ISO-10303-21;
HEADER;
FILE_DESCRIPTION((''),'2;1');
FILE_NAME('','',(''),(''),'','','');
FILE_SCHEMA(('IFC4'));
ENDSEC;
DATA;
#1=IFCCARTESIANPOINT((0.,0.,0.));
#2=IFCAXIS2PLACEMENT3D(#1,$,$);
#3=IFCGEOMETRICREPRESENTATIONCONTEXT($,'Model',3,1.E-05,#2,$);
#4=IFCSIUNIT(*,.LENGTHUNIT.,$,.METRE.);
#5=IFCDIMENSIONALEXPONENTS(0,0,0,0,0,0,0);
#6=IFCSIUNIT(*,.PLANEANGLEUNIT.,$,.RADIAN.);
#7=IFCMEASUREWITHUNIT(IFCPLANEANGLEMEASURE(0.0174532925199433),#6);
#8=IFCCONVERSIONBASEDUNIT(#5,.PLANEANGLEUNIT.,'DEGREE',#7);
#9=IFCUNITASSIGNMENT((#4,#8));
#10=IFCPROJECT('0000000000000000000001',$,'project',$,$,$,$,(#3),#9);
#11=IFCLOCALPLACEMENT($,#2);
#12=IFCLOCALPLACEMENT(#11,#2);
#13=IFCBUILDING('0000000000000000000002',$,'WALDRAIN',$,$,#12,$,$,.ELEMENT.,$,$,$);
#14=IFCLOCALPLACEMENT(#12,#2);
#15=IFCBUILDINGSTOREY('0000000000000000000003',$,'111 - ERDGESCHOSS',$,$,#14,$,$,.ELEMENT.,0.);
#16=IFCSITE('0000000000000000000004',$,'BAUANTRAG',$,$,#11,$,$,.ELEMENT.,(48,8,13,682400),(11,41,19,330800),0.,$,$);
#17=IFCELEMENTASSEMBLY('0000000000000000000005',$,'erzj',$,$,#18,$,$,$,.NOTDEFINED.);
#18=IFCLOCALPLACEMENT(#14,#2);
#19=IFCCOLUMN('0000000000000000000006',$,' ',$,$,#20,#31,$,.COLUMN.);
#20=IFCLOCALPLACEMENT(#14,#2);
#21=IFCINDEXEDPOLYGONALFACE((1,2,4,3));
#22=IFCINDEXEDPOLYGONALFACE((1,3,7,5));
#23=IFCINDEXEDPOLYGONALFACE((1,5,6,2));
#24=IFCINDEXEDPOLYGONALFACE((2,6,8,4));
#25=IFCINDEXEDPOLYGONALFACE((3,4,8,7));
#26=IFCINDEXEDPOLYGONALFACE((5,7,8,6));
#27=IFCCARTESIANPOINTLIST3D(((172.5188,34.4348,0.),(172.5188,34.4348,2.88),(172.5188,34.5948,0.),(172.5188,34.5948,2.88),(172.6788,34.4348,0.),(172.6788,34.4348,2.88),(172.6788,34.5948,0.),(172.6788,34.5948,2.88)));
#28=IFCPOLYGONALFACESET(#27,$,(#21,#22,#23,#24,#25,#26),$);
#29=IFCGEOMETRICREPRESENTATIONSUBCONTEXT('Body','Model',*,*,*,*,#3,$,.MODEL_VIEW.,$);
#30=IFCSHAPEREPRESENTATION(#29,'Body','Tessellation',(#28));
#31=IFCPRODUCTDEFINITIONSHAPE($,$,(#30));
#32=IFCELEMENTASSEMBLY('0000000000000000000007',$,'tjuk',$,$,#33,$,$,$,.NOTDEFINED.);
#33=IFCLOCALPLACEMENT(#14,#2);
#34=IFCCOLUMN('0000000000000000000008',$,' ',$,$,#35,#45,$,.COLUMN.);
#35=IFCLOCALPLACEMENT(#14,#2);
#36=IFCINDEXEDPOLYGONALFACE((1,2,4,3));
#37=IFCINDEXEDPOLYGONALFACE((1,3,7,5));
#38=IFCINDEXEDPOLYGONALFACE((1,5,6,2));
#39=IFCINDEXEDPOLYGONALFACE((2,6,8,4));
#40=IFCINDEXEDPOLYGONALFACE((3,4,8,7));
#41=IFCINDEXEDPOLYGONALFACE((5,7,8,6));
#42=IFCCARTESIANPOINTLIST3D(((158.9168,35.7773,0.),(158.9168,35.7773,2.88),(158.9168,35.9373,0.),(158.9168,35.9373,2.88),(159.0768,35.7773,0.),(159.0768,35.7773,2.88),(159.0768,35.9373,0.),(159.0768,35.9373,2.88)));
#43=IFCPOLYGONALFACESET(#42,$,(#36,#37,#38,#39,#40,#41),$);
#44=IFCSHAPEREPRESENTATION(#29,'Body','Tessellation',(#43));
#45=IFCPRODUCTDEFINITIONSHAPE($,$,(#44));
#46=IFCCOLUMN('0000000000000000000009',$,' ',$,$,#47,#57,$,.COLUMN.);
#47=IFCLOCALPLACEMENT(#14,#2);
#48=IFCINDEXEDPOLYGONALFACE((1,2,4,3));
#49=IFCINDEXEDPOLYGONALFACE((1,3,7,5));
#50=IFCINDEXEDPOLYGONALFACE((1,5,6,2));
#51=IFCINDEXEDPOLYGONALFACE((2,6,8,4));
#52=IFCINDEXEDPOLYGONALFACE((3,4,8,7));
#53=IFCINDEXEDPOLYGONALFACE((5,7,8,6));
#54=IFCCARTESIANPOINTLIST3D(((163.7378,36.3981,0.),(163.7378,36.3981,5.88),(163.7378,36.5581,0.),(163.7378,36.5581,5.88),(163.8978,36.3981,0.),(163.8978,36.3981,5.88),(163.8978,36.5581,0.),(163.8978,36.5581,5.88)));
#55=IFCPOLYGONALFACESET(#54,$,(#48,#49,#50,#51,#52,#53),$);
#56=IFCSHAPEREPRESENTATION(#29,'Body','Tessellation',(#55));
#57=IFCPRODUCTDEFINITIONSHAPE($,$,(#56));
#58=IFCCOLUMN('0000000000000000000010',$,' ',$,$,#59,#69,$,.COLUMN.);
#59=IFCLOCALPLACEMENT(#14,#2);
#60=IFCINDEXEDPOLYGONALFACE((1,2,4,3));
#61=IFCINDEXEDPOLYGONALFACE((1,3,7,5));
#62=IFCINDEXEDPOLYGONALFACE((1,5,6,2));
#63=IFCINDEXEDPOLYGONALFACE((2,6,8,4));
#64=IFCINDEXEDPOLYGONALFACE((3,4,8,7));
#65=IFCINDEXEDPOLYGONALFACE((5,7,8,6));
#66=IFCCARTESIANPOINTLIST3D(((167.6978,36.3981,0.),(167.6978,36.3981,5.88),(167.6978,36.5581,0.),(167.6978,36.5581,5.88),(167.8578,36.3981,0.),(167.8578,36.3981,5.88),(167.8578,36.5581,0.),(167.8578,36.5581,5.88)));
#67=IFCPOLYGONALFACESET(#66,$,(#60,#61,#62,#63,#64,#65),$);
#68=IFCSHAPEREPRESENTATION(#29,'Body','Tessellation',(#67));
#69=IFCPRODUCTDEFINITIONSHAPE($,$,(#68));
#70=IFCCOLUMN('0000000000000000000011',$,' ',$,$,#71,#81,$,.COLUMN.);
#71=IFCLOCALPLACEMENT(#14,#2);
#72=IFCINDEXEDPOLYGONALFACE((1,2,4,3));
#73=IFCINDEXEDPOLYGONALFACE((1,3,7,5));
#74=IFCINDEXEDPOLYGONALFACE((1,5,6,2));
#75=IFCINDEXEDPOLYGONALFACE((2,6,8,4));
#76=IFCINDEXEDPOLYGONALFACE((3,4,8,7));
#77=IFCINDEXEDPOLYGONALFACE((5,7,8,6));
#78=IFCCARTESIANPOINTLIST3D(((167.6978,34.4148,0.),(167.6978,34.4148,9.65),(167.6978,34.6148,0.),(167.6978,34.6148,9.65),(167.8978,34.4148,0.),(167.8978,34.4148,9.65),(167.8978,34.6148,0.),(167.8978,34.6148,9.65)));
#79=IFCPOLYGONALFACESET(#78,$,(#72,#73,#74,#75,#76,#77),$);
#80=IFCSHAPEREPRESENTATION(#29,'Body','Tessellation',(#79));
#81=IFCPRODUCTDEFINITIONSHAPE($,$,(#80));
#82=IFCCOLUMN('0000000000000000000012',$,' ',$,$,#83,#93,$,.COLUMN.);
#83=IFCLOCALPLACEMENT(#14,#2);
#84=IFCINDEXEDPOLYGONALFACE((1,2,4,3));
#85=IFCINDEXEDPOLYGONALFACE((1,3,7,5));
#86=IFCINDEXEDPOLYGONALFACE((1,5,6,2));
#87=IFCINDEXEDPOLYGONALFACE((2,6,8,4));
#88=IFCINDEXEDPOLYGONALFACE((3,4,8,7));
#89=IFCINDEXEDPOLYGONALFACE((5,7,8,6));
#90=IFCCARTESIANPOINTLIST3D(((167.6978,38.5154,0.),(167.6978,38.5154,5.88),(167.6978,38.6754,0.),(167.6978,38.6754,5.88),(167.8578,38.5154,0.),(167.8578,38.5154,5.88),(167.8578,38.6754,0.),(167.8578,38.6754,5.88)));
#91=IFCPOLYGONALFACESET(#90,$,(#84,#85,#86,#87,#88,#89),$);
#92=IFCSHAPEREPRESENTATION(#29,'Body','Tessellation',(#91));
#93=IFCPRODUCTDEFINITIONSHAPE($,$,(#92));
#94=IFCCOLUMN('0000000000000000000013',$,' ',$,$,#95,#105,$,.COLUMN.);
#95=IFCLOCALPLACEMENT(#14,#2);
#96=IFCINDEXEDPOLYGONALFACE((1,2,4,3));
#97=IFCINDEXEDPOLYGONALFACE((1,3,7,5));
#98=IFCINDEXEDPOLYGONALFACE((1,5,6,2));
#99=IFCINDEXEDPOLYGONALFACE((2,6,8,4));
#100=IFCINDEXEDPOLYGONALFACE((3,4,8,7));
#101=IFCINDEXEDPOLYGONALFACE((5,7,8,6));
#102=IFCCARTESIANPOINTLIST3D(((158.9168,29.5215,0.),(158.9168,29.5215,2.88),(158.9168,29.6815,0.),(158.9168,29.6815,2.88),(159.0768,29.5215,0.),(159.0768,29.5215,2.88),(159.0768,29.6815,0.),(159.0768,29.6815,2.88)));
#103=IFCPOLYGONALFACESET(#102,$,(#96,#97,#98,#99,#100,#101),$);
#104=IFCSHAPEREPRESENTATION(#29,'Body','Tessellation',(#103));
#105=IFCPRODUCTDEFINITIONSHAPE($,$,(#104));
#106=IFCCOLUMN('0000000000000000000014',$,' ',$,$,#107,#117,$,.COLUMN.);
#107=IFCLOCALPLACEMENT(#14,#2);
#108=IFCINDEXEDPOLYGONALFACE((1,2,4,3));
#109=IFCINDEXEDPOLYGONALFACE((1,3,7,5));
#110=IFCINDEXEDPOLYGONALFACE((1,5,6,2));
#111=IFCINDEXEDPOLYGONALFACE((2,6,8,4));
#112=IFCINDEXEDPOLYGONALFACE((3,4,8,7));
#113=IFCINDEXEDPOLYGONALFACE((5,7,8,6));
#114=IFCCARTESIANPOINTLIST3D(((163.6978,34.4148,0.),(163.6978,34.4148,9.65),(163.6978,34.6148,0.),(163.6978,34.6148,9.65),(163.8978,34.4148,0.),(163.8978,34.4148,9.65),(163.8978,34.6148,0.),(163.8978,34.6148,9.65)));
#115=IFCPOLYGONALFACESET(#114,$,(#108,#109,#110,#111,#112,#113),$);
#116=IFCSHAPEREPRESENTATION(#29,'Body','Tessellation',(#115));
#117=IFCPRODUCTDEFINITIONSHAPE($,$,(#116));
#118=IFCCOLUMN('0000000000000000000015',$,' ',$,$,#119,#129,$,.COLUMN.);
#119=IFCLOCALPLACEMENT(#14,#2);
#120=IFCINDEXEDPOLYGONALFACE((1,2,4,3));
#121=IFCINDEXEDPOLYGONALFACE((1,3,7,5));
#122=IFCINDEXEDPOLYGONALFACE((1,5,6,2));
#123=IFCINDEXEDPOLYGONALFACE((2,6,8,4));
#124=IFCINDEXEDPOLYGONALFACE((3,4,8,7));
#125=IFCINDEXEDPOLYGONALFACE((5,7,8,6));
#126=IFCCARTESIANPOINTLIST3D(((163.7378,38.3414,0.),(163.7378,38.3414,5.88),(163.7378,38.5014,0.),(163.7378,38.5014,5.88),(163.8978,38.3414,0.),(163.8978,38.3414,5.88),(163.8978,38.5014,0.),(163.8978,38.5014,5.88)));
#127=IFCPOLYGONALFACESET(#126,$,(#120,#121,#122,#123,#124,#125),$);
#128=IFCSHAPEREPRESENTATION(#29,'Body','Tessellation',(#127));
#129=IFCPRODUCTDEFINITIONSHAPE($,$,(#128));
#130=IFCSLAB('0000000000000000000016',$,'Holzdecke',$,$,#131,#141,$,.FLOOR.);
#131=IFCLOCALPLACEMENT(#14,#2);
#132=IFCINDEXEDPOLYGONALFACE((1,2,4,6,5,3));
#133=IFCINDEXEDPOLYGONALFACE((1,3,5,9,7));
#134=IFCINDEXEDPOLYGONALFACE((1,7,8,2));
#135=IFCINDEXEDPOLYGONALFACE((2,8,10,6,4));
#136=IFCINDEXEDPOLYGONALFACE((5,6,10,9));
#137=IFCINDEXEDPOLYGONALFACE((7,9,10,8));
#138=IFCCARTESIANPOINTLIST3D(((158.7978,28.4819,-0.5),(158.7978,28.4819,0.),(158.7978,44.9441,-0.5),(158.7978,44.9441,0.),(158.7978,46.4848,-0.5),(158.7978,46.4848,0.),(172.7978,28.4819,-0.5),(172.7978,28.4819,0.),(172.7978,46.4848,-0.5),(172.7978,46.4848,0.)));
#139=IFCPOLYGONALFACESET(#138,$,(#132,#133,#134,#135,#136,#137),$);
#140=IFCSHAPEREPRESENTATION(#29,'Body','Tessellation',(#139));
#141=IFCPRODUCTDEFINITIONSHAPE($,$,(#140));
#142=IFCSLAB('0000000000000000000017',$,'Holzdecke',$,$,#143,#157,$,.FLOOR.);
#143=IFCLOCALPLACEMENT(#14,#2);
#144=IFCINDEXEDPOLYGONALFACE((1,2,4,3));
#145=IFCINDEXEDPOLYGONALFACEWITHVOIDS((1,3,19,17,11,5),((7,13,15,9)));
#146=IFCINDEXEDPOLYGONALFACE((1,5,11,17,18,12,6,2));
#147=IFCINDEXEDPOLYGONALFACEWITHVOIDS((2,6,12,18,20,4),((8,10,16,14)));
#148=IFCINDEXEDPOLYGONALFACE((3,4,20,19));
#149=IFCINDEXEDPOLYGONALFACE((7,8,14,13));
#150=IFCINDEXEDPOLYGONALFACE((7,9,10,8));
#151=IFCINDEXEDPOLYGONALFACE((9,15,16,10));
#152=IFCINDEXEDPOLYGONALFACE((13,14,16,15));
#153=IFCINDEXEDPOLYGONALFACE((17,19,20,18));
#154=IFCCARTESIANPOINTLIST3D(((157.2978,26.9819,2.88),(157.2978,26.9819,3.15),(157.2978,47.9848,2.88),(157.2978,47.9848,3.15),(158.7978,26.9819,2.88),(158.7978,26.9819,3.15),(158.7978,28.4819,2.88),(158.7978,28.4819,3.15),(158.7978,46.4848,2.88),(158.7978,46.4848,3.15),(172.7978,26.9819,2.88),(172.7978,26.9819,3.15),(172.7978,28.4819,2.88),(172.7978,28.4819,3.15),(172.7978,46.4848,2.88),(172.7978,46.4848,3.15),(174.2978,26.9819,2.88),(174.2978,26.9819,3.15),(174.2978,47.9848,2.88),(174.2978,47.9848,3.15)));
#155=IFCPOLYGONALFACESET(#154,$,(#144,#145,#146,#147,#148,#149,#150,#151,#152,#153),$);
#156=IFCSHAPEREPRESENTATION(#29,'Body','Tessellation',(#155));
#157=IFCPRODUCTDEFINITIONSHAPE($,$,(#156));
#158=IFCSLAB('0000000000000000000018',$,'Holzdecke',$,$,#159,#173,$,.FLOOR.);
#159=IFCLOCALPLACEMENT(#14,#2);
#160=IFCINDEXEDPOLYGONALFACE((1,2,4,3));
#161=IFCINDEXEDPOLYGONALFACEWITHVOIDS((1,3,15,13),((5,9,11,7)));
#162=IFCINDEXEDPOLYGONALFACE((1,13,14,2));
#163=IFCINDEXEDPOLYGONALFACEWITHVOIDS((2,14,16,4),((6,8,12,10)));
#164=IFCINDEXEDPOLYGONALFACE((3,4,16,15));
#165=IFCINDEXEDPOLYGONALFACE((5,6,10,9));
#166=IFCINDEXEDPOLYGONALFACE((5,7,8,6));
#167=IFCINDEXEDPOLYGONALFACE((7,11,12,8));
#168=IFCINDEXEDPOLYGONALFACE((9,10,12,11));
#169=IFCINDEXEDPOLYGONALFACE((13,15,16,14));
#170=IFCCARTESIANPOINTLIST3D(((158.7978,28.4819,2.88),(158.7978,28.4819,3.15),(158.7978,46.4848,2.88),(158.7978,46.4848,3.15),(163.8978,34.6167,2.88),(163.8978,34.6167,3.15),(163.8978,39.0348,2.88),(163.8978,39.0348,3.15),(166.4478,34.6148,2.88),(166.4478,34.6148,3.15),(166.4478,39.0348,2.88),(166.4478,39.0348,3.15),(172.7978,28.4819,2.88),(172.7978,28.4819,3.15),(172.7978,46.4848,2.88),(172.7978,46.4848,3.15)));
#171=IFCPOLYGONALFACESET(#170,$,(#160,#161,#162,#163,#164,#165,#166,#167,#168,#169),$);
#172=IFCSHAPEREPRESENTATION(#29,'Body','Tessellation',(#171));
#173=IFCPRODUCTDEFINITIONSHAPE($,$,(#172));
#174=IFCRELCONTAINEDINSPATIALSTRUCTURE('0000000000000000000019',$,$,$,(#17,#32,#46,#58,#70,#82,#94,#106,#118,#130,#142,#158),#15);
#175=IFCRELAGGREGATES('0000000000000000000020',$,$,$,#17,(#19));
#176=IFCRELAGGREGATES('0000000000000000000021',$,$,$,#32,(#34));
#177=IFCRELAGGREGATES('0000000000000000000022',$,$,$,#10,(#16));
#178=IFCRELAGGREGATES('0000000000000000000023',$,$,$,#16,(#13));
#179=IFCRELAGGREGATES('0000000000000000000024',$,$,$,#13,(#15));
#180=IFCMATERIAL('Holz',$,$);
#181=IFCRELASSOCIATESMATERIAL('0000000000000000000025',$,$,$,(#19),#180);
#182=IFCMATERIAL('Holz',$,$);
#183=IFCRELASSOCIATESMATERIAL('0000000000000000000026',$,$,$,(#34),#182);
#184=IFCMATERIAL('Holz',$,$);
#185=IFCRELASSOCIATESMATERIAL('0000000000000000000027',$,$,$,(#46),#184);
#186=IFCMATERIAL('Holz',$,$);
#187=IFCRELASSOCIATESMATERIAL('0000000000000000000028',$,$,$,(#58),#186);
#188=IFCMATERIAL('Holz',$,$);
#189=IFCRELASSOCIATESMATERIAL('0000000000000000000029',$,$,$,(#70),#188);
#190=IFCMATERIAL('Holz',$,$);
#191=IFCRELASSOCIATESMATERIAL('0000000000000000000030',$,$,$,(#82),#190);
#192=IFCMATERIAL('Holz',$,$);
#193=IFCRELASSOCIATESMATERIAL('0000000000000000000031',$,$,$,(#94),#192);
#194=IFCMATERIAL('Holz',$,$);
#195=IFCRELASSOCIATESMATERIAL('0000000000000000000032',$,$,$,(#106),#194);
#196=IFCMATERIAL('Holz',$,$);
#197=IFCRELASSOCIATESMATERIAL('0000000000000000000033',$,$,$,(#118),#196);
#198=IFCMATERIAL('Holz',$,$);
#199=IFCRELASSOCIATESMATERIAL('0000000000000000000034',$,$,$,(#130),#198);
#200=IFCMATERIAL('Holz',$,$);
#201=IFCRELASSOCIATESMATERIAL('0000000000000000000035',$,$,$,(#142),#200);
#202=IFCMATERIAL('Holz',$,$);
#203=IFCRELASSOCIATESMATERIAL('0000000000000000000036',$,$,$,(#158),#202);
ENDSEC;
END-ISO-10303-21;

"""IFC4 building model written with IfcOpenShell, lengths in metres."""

from ifc_helpers import new_model, entity, si_unit, converted_unit, frame, frame_2d, origin, origin_with_axes, place, context, subcontext, project, spatial, polyline, rectangle, outline, extrude, material, element, aggregate, save


model = new_model("IFC4")

# Units and contexts
model_context = context("Model", 3, precision=1e-05, world=origin())
body_context = subcontext(model_context, "Body", "Model", "MODEL_VIEW")
ifc_project = project(units=[si_unit("LENGTHUNIT", "METRE"), converted_unit("PLANEANGLEUNIT", "DEGREE", entity("IfcPlaneAngleMeasure", 0.0174532925199433), si_unit("PLANEANGLEUNIT", "RADIAN"), dimensions=[0, 0, 0, 0, 0, 0, 0])], contexts=[model_context])

# Site, building, storey
site_placement = place(None, origin())
site = spatial("IfcSite", under=ifc_project, at=site_placement, Name="BAUANTRAG", CompositionType="ELEMENT", RefLatitude=(48, 8, 13, 682400), RefLongitude=(11, 41, 19, 330800), RefElevation=0.0)
building_placement = place(site_placement, origin())
building = spatial("IfcBuilding", under=site, at=building_placement, Name="WALDRAIN", CompositionType="ELEMENT")
storey_placement = place(building_placement, origin())
storey = spatial("IfcBuildingStorey", under=building, at=storey_placement, Name="111 - ERDGESCHOSS", CompositionType="ELEMENT", Elevation=0.0)

# Element assemblies, columns
assembly_1_placement = place(storey_placement, origin())
assembly_1 = element("IfcElementAssembly", 1, at=assembly_1_placement, inside=storey, Name="erzj", PredefinedType="NOTDEFINED")
ifc_material_1 = material(Name="Holz")
column_1_placement = place(assembly_1_placement, frame((172.5188, 34.4348, 0.0)))
column_1 = element("IfcColumn", 2, at=column_1_placement, material=ifc_material_1, Name=" ", PredefinedType="COLUMN", context=body_context, shape_type="SweptSolid", body=[
    extrude(rectangle(XDim=0.16, YDim=0.16, at=frame_2d((0.08, 0.08), x_axis=(1.0, 0.0))), origin_with_axes(), (0.0, 0.0, 1.0), 2.88),
])
aggregate(assembly_1, [column_1])
assembly_2_placement = place(storey_placement, origin())
assembly_2 = element("IfcElementAssembly", 3, at=assembly_2_placement, inside=storey, Name="tjuk", PredefinedType="NOTDEFINED")
ifc_material_2 = material(Name="Holz")
column_2_placement = place(assembly_2_placement, frame((158.9168, 35.7773, 0.0)))
column_2 = element("IfcColumn", 4, at=column_2_placement, material=ifc_material_2, Name=" ", PredefinedType="COLUMN", context=body_context, shape_type="SweptSolid", body=[
    extrude(rectangle(XDim=0.16, YDim=0.16, at=frame_2d((0.08, 0.08), x_axis=(1.0, 0.0))), origin_with_axes(), (0.0, 0.0, 1.0), 2.88),
])
aggregate(assembly_2, [column_2])

# Columns
ifc_material_3 = material(Name="Holz")
column_3_placement = place(storey_placement, frame((163.7378, 36.3981, 0.0)))
element("IfcColumn", 5, at=column_3_placement, inside=storey, material=ifc_material_3, Name=" ", PredefinedType="COLUMN", context=body_context, shape_type="SweptSolid", body=[
    extrude(rectangle(XDim=0.16, YDim=0.16, at=frame_2d((0.08, 0.08), x_axis=(1.0, 0.0))), origin_with_axes(), (0.0, 0.0, 1.0), 5.88),
])
ifc_material_4 = material(Name="Holz")
column_4_placement = place(storey_placement, frame((167.6978, 36.3981, 0.0)))
element("IfcColumn", 6, at=column_4_placement, inside=storey, material=ifc_material_4, Name=" ", PredefinedType="COLUMN", context=body_context, shape_type="SweptSolid", body=[
    extrude(rectangle(XDim=0.16, YDim=0.16, at=frame_2d((0.08, 0.08), x_axis=(1.0, 0.0))), origin_with_axes(), (0.0, 0.0, 1.0), 5.88),
])
ifc_material_5 = material(Name="Holz")
column_5_placement = place(storey_placement, frame((167.6978, 34.4148, 0.0)))
element("IfcColumn", 7, at=column_5_placement, inside=storey, material=ifc_material_5, Name=" ", PredefinedType="COLUMN", context=body_context, shape_type="SweptSolid", body=[
    extrude(rectangle(XDim=0.2, YDim=0.2, at=frame_2d((0.1, 0.1), x_axis=(1.0, 0.0))), origin_with_axes(), (0.0, 0.0, 1.0), 9.65),
])
ifc_material_6 = material(Name="Holz")
column_6_placement = place(storey_placement, frame((167.6978, 38.5154, 0.0)))
element("IfcColumn", 8, at=column_6_placement, inside=storey, material=ifc_material_6, Name=" ", PredefinedType="COLUMN", context=body_context, shape_type="SweptSolid", body=[
    extrude(rectangle(XDim=0.16, YDim=0.16, at=frame_2d((0.08, 0.08), x_axis=(1.0, 0.0))), origin_with_axes(), (0.0, 0.0, 1.0), 5.88),
])
ifc_material_7 = material(Name="Holz")
column_7_placement = place(storey_placement, frame((158.9168, 29.5215, 0.0)))
element("IfcColumn", 9, at=column_7_placement, inside=storey, material=ifc_material_7, Name=" ", PredefinedType="COLUMN", context=body_context, shape_type="SweptSolid", body=[
    extrude(rectangle(XDim=0.16, YDim=0.16, at=frame_2d((0.08, 0.08), x_axis=(1.0, 0.0))), origin_with_axes(), (0.0, 0.0, 1.0), 2.88),
])
ifc_material_8 = material(Name="Holz")
column_8_placement = place(storey_placement, frame((163.6978, 34.4148, 0.0)))
element("IfcColumn", 10, at=column_8_placement, inside=storey, material=ifc_material_8, Name=" ", PredefinedType="COLUMN", context=body_context, shape_type="SweptSolid", body=[
    extrude(rectangle(XDim=0.2, YDim=0.2, at=frame_2d((0.1, 0.1), x_axis=(1.0, 0.0))), origin_with_axes(), (0.0, 0.0, 1.0), 9.65),
])
ifc_material_9 = material(Name="Holz")
column_9_placement = place(storey_placement, frame((163.7378, 38.3414, 0.0)))
element("IfcColumn", 11, at=column_9_placement, inside=storey, material=ifc_material_9, Name=" ", PredefinedType="COLUMN", context=body_context, shape_type="SweptSolid", body=[
    extrude(rectangle(XDim=0.16, YDim=0.16, at=frame_2d((0.08, 0.08), x_axis=(1.0, 0.0))), origin_with_axes(), (0.0, 0.0, 1.0), 5.88),
])

# Slabs
ifc_material_10 = material(Name="Holz")
slab_1_placement = place(storey_placement, frame((158.7978, 28.4819, -0.5)))
element("IfcSlab", 12, at=slab_1_placement, inside=storey, material=ifc_material_10, Name="Holzdecke", PredefinedType="FLOOR", context=body_context, shape_type="SweptSolid", body=[
    extrude(outline(polyline([(0.0, 16.4622), (0.0, 0.0), (14.0, 0.0), (14.0, 18.0029), (0.0, 18.0029), (0.0, 16.4622)])), origin_with_axes(), (0.0, 0.0, 1.0), 0.5),
])
ifc_material_11 = material(Name="Holz")
slab_2_placement = place(storey_placement, frame((157.2978, 26.9819, 2.88)))
element("IfcSlab", 13, at=slab_2_placement, inside=storey, material=ifc_material_11, Name="Holzdecke", PredefinedType="FLOOR", context=body_context, shape_type="SweptSolid", body=[
    extrude(outline(polyline([(17.0, 0.0), (17.0, 21.0029), (0.0, 21.0029), (0.0, 0.0), (1.5, 0.0), (15.5, 0.0), (17.0, 0.0)]), holes=[polyline([(15.5, 19.5029), (15.5, 1.5), (1.5, 1.5), (1.5, 19.5029), (15.5, 19.5029)])]), origin_with_axes(), (0.0, 0.0, 1.0), 0.27),
])

# Slab, opening
ifc_material_12 = material(Name="Holz")
slab_3_placement = place(storey_placement, frame((158.7978, 28.4819, 2.88)))
slab_3 = element("IfcSlab", 14, at=slab_3_placement, inside=storey, material=ifc_material_12, Name="Holzdecke", PredefinedType="FLOOR", context=body_context, shape_type="SweptSolid", body=[
    extrude(rectangle(XDim=18.0029, YDim=14.0, at=frame_2d((-7.0, 9.0014), x_axis=(0.0, 1.0))), frame((14.0, 0.0, 0.0), z_axis=(0.0, 0.0, 1.0), x_axis=(1.0, 0.0, 0.0)), (0.0, 0.0, 1.0), 0.27),
])
opening_1_placement = place(slab_3_placement, frame((5.1, 6.1329, 0.0)))
element("IfcOpeningElement", 15, at=opening_1_placement, cuts=slab_3, ObjectType="Opening", context=body_context, shape_type="SweptSolid", body=[
    extrude(outline(polyline([(1.275, 2.2095), (-1.275, 2.2095), (-1.275, -2.2086), (1.275, -2.2105), (1.275, 2.2095)])), frame((1.275, 2.2105, 0.0), z_axis=(0.0, 0.0, 1.0), x_axis=(1.0, 0.0, 0.0)), (0.0, 0.0, 1.0), 0.27),
])

save(model, "model.ifc")
